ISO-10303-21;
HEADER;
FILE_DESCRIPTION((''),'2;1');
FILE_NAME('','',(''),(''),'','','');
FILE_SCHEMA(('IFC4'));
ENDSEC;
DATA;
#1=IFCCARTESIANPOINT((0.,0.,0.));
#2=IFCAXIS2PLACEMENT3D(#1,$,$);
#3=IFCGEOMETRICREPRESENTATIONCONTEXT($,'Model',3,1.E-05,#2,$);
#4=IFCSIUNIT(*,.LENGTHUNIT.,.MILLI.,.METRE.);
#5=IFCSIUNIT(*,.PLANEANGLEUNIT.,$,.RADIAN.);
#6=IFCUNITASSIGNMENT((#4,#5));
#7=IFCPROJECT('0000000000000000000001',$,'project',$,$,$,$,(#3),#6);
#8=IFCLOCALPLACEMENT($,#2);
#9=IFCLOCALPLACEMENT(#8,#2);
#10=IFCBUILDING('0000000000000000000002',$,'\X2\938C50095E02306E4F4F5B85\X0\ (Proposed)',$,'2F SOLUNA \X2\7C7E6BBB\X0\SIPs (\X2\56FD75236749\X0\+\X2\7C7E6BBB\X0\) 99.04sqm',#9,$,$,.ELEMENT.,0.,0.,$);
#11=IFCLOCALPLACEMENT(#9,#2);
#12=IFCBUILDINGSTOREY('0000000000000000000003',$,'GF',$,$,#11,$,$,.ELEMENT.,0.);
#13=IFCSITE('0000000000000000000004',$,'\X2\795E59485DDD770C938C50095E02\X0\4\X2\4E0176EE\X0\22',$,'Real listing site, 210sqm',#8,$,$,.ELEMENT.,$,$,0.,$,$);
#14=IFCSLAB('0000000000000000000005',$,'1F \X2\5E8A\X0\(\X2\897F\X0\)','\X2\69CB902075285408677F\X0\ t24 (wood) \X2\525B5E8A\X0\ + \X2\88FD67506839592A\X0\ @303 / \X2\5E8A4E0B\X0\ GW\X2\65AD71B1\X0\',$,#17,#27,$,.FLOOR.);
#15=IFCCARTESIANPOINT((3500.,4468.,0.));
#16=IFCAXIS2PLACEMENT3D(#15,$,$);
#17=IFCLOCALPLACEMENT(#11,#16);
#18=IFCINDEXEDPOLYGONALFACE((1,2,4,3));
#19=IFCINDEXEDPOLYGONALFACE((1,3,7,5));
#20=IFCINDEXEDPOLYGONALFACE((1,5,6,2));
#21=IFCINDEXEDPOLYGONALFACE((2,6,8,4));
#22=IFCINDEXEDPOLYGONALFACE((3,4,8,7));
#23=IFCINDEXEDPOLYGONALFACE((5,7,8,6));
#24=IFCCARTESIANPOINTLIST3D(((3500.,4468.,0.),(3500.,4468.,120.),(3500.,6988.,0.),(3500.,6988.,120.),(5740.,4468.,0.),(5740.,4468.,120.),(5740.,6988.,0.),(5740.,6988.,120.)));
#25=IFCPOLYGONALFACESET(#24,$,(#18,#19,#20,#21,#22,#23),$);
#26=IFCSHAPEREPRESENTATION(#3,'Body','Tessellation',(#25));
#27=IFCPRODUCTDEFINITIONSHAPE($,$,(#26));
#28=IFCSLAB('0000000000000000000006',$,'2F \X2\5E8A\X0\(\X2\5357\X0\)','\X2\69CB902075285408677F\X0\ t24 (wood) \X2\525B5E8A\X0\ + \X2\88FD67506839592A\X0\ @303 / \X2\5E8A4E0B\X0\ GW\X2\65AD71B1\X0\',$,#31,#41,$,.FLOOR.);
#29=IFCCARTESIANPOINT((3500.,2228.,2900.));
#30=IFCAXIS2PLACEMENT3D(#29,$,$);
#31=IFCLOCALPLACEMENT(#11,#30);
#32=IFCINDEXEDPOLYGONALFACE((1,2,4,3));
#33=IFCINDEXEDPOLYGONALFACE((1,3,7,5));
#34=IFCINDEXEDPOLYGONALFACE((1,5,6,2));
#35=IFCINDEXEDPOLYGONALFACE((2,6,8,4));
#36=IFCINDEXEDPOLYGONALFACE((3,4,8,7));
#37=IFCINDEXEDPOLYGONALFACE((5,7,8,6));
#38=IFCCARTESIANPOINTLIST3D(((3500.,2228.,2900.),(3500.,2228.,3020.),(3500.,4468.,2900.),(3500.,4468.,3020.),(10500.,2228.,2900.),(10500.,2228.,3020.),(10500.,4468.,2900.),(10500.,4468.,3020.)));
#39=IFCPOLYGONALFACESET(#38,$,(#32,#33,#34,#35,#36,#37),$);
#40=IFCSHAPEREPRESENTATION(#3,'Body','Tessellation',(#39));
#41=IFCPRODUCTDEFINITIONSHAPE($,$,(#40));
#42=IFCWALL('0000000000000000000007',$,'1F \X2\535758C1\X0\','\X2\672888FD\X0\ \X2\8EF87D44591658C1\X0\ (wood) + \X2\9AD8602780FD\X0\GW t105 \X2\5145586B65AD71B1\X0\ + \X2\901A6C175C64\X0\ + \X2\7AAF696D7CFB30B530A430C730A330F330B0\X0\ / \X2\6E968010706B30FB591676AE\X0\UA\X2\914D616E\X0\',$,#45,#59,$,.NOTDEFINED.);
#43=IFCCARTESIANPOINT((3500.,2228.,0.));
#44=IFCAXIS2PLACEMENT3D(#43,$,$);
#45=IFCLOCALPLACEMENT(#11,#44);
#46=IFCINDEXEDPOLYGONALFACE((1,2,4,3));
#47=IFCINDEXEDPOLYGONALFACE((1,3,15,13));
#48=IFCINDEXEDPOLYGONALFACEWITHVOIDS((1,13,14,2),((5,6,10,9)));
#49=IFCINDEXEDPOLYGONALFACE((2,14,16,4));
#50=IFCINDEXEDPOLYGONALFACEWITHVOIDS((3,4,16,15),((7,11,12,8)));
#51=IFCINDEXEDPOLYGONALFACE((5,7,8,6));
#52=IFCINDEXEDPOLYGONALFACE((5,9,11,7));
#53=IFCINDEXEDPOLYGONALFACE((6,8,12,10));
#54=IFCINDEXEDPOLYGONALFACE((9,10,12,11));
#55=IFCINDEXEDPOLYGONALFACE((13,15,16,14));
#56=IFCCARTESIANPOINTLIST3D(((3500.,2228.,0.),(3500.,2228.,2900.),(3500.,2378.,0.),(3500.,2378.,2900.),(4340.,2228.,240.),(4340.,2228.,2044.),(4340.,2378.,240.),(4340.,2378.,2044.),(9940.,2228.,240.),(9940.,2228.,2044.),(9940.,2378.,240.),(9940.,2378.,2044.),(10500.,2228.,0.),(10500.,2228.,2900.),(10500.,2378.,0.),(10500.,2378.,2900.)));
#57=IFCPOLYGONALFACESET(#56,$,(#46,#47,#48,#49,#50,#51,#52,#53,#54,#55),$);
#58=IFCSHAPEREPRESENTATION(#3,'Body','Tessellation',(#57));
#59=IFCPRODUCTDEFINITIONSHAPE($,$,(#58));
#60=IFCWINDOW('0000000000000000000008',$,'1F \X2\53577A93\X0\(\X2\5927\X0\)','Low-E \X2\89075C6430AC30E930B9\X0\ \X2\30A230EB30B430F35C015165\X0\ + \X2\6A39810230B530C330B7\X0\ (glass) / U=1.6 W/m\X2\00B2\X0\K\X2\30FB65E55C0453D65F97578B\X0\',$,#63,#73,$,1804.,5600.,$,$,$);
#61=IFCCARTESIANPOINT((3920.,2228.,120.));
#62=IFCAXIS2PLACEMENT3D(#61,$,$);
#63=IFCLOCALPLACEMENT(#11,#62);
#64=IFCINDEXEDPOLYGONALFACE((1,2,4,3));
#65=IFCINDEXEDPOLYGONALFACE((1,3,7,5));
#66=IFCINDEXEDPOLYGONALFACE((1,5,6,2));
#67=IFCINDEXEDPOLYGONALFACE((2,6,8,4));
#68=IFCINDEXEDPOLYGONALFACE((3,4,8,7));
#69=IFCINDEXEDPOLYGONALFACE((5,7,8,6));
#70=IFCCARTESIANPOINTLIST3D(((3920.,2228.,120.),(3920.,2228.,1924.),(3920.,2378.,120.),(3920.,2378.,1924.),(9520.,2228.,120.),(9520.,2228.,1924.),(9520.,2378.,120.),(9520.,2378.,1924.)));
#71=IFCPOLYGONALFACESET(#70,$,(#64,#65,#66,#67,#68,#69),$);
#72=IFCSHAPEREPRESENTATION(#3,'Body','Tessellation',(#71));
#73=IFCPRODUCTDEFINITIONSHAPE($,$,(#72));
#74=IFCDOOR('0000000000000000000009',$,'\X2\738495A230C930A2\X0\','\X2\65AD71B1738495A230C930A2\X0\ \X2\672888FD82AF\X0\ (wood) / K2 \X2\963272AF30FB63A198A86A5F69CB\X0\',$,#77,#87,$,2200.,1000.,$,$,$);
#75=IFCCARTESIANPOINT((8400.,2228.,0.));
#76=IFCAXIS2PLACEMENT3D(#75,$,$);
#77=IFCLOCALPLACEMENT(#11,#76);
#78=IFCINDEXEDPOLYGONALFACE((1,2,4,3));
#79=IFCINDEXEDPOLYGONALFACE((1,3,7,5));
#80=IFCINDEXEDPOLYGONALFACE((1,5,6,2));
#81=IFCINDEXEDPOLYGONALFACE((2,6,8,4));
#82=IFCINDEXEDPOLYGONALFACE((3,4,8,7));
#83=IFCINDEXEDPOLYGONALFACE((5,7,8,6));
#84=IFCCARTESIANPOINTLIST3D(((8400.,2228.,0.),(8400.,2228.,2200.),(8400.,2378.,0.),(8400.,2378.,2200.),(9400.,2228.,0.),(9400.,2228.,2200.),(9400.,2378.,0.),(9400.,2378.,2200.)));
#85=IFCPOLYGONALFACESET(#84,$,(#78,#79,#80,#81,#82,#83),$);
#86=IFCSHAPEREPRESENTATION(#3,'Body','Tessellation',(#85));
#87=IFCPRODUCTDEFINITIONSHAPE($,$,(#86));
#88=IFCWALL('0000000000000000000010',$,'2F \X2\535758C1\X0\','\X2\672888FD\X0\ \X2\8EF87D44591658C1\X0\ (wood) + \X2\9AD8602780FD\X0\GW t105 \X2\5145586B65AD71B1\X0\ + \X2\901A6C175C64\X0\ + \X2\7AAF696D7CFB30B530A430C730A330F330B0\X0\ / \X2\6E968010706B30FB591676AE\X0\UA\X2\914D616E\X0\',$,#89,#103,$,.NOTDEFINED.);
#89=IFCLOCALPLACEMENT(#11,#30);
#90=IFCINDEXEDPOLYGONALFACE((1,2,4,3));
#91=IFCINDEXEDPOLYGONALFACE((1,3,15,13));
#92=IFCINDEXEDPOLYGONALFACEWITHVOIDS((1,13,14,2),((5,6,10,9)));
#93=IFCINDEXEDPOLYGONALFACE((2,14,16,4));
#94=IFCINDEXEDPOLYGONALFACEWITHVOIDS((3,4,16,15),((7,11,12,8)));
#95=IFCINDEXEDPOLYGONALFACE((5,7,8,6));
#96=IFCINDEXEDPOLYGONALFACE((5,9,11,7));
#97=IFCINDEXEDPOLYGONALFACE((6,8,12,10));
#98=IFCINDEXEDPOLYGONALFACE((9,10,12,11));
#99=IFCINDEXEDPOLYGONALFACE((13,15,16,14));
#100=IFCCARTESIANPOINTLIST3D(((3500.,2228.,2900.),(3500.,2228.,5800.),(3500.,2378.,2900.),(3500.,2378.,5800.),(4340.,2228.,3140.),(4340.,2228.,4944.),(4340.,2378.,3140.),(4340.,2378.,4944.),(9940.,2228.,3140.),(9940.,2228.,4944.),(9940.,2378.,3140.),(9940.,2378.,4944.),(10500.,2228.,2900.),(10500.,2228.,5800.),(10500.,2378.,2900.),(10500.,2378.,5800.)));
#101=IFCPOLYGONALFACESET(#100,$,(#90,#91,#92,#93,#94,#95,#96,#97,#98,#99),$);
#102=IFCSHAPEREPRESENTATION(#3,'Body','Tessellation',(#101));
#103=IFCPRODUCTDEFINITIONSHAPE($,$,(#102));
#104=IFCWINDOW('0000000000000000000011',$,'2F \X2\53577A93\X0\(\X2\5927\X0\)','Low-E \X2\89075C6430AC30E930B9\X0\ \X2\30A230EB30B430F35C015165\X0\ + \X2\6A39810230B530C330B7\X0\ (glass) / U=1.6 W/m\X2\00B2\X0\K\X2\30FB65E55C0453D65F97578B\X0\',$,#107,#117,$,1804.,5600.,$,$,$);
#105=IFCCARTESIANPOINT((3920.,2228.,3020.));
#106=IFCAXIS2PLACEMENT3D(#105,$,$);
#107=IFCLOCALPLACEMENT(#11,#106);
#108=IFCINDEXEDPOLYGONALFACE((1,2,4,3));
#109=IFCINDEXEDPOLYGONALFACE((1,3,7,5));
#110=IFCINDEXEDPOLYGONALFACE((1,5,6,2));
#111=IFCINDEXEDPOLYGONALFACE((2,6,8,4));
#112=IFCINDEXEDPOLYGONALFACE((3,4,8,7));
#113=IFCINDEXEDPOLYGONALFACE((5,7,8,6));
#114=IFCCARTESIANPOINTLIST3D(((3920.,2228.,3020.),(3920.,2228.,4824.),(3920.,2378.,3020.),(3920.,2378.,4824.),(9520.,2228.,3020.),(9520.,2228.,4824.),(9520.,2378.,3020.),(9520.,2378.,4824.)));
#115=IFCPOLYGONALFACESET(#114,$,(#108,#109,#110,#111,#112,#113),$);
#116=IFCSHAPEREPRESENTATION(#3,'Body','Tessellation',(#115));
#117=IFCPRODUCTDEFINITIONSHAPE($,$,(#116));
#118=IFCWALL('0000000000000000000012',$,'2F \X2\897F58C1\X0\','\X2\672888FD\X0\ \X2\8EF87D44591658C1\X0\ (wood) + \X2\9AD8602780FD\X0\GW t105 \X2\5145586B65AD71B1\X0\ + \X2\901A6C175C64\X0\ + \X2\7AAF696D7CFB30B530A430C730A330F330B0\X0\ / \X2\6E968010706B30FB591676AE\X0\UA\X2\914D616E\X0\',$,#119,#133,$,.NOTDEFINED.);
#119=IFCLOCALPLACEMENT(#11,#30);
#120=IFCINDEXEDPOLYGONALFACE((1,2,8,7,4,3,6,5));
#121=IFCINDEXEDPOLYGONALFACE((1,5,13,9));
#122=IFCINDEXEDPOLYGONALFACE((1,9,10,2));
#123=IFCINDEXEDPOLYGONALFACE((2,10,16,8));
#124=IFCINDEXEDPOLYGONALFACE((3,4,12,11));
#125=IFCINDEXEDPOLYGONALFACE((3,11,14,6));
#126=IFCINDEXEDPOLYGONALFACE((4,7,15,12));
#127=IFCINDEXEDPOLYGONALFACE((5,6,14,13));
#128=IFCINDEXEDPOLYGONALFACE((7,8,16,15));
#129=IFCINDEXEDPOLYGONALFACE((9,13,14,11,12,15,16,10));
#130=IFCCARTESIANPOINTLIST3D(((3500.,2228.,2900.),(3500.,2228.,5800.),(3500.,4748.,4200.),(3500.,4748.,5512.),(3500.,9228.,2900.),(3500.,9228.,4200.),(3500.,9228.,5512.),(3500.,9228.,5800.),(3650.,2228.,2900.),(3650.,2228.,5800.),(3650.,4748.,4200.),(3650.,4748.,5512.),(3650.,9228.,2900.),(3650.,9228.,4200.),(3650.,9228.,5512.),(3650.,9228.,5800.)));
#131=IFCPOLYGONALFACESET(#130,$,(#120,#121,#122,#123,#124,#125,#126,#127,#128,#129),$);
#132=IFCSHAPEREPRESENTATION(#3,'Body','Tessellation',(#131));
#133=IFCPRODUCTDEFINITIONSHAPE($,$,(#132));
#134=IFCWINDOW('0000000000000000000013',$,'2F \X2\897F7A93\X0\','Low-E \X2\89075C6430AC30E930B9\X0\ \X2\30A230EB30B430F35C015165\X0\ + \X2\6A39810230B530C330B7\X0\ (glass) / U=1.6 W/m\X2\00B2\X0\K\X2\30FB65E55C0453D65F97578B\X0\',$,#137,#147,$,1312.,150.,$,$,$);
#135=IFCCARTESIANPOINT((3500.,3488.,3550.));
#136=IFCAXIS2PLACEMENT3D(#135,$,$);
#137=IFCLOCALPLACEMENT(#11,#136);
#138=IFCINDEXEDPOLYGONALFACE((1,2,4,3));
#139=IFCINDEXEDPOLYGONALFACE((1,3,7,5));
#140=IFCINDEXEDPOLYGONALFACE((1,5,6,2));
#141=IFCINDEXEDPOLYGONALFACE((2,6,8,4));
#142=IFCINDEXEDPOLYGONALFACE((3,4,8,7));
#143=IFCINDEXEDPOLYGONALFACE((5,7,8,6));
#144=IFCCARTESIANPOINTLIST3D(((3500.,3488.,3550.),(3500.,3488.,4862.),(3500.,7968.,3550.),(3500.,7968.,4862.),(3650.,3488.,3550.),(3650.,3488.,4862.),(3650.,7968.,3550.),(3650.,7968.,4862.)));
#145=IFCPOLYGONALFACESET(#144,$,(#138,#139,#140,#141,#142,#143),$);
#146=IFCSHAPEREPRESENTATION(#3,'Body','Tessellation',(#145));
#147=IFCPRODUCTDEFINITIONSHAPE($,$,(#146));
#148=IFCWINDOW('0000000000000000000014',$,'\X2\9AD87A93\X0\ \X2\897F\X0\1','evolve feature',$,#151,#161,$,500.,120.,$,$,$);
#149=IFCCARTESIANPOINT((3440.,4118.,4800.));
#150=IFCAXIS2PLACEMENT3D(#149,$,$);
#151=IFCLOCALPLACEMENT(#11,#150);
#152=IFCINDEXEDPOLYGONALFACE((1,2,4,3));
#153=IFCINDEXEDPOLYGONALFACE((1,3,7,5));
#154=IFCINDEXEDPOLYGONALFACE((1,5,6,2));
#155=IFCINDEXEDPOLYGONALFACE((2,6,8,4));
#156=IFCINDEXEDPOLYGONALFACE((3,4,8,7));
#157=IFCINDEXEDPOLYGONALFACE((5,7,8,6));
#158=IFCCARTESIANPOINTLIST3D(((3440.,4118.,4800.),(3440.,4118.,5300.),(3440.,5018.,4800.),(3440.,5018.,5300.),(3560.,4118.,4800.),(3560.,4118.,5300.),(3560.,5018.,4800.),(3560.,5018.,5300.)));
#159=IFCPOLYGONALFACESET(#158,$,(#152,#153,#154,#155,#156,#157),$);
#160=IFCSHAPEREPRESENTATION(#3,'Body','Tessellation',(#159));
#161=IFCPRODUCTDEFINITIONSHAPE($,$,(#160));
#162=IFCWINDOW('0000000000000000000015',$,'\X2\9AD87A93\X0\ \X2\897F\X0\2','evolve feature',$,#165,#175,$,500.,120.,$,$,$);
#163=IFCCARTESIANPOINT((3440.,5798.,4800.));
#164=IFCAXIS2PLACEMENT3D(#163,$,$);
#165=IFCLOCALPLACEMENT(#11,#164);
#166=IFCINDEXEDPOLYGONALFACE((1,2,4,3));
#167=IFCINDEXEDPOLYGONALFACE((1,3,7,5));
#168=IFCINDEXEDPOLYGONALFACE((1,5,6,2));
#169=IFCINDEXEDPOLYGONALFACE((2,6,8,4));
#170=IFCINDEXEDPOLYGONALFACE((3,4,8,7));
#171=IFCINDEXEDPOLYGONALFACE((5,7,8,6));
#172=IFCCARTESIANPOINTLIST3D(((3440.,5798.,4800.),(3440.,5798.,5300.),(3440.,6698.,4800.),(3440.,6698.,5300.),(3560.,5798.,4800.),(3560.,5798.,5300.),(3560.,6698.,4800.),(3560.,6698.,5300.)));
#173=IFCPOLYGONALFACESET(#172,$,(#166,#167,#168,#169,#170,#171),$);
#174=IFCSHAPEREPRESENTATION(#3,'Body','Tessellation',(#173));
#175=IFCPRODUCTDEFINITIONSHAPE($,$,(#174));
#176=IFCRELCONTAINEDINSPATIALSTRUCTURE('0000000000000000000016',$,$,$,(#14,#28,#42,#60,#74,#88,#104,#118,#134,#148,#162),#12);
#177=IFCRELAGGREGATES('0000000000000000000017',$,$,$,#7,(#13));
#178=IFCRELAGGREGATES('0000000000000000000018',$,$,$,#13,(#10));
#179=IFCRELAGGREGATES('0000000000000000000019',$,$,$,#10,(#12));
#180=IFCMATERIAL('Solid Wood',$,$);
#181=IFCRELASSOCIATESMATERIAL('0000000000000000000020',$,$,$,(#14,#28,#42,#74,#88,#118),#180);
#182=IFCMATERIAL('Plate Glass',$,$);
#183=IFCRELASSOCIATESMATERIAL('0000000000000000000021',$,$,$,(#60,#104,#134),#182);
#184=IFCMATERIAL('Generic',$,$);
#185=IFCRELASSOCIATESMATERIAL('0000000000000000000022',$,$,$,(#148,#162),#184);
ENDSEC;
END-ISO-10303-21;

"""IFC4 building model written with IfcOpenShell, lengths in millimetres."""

from ifc_helpers import new_model, si_unit, frame, frame_2d, origin, place, context, project, spatial, rectangle, extrude, material, element, fill, save


model = new_model("IFC4")

# Units and contexts
model_context = context("Model", 3, precision=1e-05, world=origin())
ifc_project = project(units=[si_unit("LENGTHUNIT", "METRE", prefix="MILLI"), si_unit("PLANEANGLEUNIT", "RADIAN")], contexts=[model_context])

# Site, building, storey
site_placement = place(None, origin())
site = spatial("IfcSite", under=ifc_project, at=site_placement, Name="神奈川県鎌倉市4丁目22", ObjectType="Real listing site, 210sqm", CompositionType="ELEMENT", RefElevation=0.0)
building_placement = place(site_placement, origin())
building = spatial("IfcBuilding", under=site, at=building_placement, Name="鎌倉市の住宅 (Proposed)", ObjectType="2F SOLUNA 籾殻SIPs (国産杉+籾殻) 99.04sqm", CompositionType="ELEMENT", ElevationOfRefHeight=0.0, ElevationOfTerrain=0.0)
storey_placement = place(building_placement, origin())
storey = spatial("IfcBuildingStorey", under=building, at=storey_placement, Name="GF", CompositionType="ELEMENT", Elevation=0.0)

# Slabs
ifc_material_1 = material(Name="Solid Wood")
slab_1_placement = place(storey_placement, frame((3500.0, 4468.0, 0.0)))
element("IfcSlab", 1, at=slab_1_placement, inside=storey, material=ifc_material_1, Name="1F 床(西)", Description="構造用合板 t24 (wood) 剛床 + 製材根太 @303 / 床下 GW断熱", PredefinedType="FLOOR", context=model_context, shape_type="SweptSolid", body=[
    extrude(rectangle(XDim=2240.0, YDim=2520.0, at=frame_2d((1120.0, 1260.0))), frame((3500.0, 4468.0, 0.0)), (0.0, 0.0, 1.0), 120.0),
])
slab_2_placement = place(storey_placement, frame((3500.0, 2228.0, 2900.0)))
element("IfcSlab", 2, at=slab_2_placement, inside=storey, material=ifc_material_1, Name="2F 床(南)", Description="構造用合板 t24 (wood) 剛床 + 製材根太 @303 / 床下 GW断熱", PredefinedType="FLOOR", context=model_context, shape_type="SweptSolid", body=[
    extrude(rectangle(XDim=7000.0, YDim=2240.0, at=frame_2d((3500.0, 1120.0))), frame((3500.0, 2228.0, 2900.0)), (0.0, 0.0, 1.0), 120.0),
])
ifc_material_2 = material(Name="Generic")

# Wall, openings, window, door
wall_1_placement = place(storey_placement, frame((3500.0, 2228.0, 0.0)))
wall_1 = element("IfcWall", 3, at=wall_1_placement, inside=storey, material=ifc_material_1, Name="1F 南壁", Description="木製 軸組外壁 (wood) + 高性能GW t105 充填断熱 + 通気層 + 窯業系サイディング / 準耐火・外皮UA配慮", PredefinedType="NOTDEFINED", context=model_context, shape_type="SweptSolid", body=[
    extrude(rectangle(XDim=7000.0, YDim=150.0, at=frame_2d((3500.0, 75.0))), frame((3500.0, 2228.0, 0.0)), (0.0, 0.0, 1.0), 2900.0),
])
opening_1_placement = place(storey_placement, frame((3920.0, 2228.0, 120.0)))
opening_1 = element("IfcOpeningElement", 4, at=opening_1_placement, cuts=wall_1, PredefinedType="NOTDEFINED", context=model_context, shape_type="SweptSolid", body=[
    extrude(rectangle(XDim=5600.0, YDim=150.0, at=frame_2d((2800.0, 75.0))), frame((3920.0, 2228.0, 120.0)), (0.0, 0.0, 1.0), 1804.0),
])
opening_2_placement = place(storey_placement, frame((8400.0, 2228.0, 0.0)))
opening_2 = element("IfcOpeningElement", 5, at=opening_2_placement, cuts=wall_1, PredefinedType="NOTDEFINED", context=model_context, shape_type="SweptSolid", body=[
    extrude(rectangle(XDim=1000.0, YDim=150.0, at=frame_2d((500.0, 75.0))), frame((8400.0, 2228.0, 0.0)), (0.0, 0.0, 1.0), 2200.0),
])
ifc_material_3 = material(Name="Plate Glass")
window_1_placement = place(storey_placement, frame((3920.0, 2228.0, 120.0)))
window_1 = element("IfcWindow", 6, at=window_1_placement, inside=storey, material=ifc_material_3, Name="1F 南窓(大)", Description="Low-E 複層ガラス アルゴン封入 + 樹脂サッシ (glass) / U=1.6 W/m²K・日射取得型", OverallHeight=1804.0, OverallWidth=5600.0, context=model_context, shape_type="SweptSolid", body=[
    extrude(rectangle(XDim=5600.0, YDim=150.0, at=frame_2d((2800.0, 75.0))), frame((3920.0, 2228.0, 120.0)), (0.0, 0.0, 1.0), 1804.0),
])
fill(opening_1, window_1)
door_placement = place(storey_placement, frame((8400.0, 2228.0, 0.0)))
door = element("IfcDoor", 7, at=door_placement, inside=storey, material=ifc_material_1, Name="玄関ドア", Description="断熱玄関ドア 木製芯 (wood) / K2 防犯・採風機構", OverallHeight=2200.0, OverallWidth=1000.0, context=model_context, shape_type="SweptSolid", body=[
    extrude(rectangle(XDim=1000.0, YDim=150.0, at=frame_2d((500.0, 75.0))), frame((8400.0, 2228.0, 0.0)), (0.0, 0.0, 1.0), 2200.0),
])
fill(opening_2, door)

# Wall, opening, window
wall_2_placement = place(storey_placement, frame((3500.0, 2228.0, 2900.0)))
wall_2 = element("IfcWall", 8, at=wall_2_placement, inside=storey, material=ifc_material_1, Name="2F 南壁", Description="木製 軸組外壁 (wood) + 高性能GW t105 充填断熱 + 通気層 + 窯業系サイディング / 準耐火・外皮UA配慮", PredefinedType="NOTDEFINED", context=model_context, shape_type="SweptSolid", body=[
    extrude(rectangle(XDim=7000.0, YDim=150.0, at=frame_2d((3500.0, 75.0))), frame((3500.0, 2228.0, 2900.0)), (0.0, 0.0, 1.0), 2900.0),
])
opening_3_placement = place(storey_placement, frame((3920.0, 2228.0, 3020.0)))
opening_3 = element("IfcOpeningElement", 9, at=opening_3_placement, cuts=wall_2, PredefinedType="NOTDEFINED", context=model_context, shape_type="SweptSolid", body=[
    extrude(rectangle(XDim=5600.0, YDim=150.0, at=frame_2d((2800.0, 75.0))), frame((3920.0, 2228.0, 3020.0)), (0.0, 0.0, 1.0), 1804.0),
])
window_2_placement = place(storey_placement, frame((3920.0, 2228.0, 3020.0)))
window_2 = element("IfcWindow", 10, at=window_2_placement, inside=storey, material=ifc_material_3, Name="2F 南窓(大)", Description="Low-E 複層ガラス アルゴン封入 + 樹脂サッシ (glass) / U=1.6 W/m²K・日射取得型", OverallHeight=1804.0, OverallWidth=5600.0, context=model_context, shape_type="SweptSolid", body=[
    extrude(rectangle(XDim=5600.0, YDim=150.0, at=frame_2d((2800.0, 75.0))), frame((3920.0, 2228.0, 3020.0)), (0.0, 0.0, 1.0), 1804.0),
])
fill(opening_3, window_2)

# Wall, openings, windows
wall_3_placement = place(storey_placement, frame((3500.0, 2228.0, 2900.0)))
wall_3 = element("IfcWall", 11, at=wall_3_placement, inside=storey, material=ifc_material_1, Name="2F 西壁", Description="木製 軸組外壁 (wood) + 高性能GW t105 充填断熱 + 通気層 + 窯業系サイディング / 準耐火・外皮UA配慮", PredefinedType="NOTDEFINED", context=model_context, shape_type="SweptSolid", body=[
    extrude(rectangle(XDim=150.0, YDim=7000.0, at=frame_2d((75.0, 3500.0))), frame((3500.0, 2228.0, 2900.0)), (0.0, 0.0, 1.0), 2900.0),
])
opening_4_placement = place(storey_placement, frame((3500.0, 3488.0, 3550.0)))
opening_4 = element("IfcOpeningElement", 12, at=opening_4_placement, cuts=wall_3, PredefinedType="NOTDEFINED", context=model_context, shape_type="SweptSolid", body=[
    extrude(rectangle(XDim=150.0, YDim=4480.0, at=frame_2d((75.0, 2240.0))), frame((3500.0, 3488.0, 3550.0)), (0.0, 0.0, 1.0), 1312.0),
])
opening_5_placement = place(storey_placement, frame((3440.0, 4118.0, 4800.0)))
opening_5 = element("IfcOpeningElement", 13, at=opening_5_placement, cuts=wall_3, PredefinedType="NOTDEFINED", context=model_context, shape_type="SweptSolid", body=[
    extrude(rectangle(XDim=120.0, YDim=900.0, at=frame_2d((60.0, 450.0))), frame((3440.0, 4118.0, 4800.0)), (0.0, 0.0, 1.0), 500.0),
])
opening_6_placement = place(storey_placement, frame((3440.0, 5798.0, 4800.0)))
opening_6 = element("IfcOpeningElement", 14, at=opening_6_placement, cuts=wall_3, PredefinedType="NOTDEFINED", context=model_context, shape_type="SweptSolid", body=[
    extrude(rectangle(XDim=120.0, YDim=900.0, at=frame_2d((60.0, 450.0))), frame((3440.0, 5798.0, 4800.0)), (0.0, 0.0, 1.0), 500.0),
])
window_3_placement = place(storey_placement, frame((3500.0, 3488.0, 3550.0)))
window_3 = element("IfcWindow", 15, at=window_3_placement, inside=storey, material=ifc_material_3, Name="2F 西窓", Description="Low-E 複層ガラス アルゴン封入 + 樹脂サッシ (glass) / U=1.6 W/m²K・日射取得型", OverallHeight=1312.0, OverallWidth=150.0, context=model_context, shape_type="SweptSolid", body=[
    extrude(rectangle(XDim=150.0, YDim=4480.0, at=frame_2d((75.0, 2240.0))), frame((3500.0, 3488.0, 3550.0)), (0.0, 0.0, 1.0), 1312.0),
])
fill(opening_4, window_3)
window_4_placement = place(storey_placement, frame((3440.0, 4118.0, 4800.0)))
window_4 = element("IfcWindow", 16, at=window_4_placement, inside=storey, material=ifc_material_2, Name="高窓 西1", Description="evolve feature", OverallHeight=500.0, OverallWidth=120.0, context=model_context, shape_type="SweptSolid", body=[
    extrude(rectangle(XDim=120.0, YDim=900.0, at=frame_2d((60.0, 450.0))), frame((3440.0, 4118.0, 4800.0)), (0.0, 0.0, 1.0), 500.0),
])
fill(opening_5, window_4)
window_5_placement = place(storey_placement, frame((3440.0, 5798.0, 4800.0)))
window_5 = element("IfcWindow", 17, at=window_5_placement, inside=storey, material=ifc_material_2, Name="高窓 西2", Description="evolve feature", OverallHeight=500.0, OverallWidth=120.0, context=model_context, shape_type="SweptSolid", body=[
    extrude(rectangle(XDim=120.0, YDim=900.0, at=frame_2d((60.0, 450.0))), frame((3440.0, 5798.0, 4800.0)), (0.0, 0.0, 1.0), 500.0),
])
fill(opening_6, window_5)

save(model, "model.ifc")
